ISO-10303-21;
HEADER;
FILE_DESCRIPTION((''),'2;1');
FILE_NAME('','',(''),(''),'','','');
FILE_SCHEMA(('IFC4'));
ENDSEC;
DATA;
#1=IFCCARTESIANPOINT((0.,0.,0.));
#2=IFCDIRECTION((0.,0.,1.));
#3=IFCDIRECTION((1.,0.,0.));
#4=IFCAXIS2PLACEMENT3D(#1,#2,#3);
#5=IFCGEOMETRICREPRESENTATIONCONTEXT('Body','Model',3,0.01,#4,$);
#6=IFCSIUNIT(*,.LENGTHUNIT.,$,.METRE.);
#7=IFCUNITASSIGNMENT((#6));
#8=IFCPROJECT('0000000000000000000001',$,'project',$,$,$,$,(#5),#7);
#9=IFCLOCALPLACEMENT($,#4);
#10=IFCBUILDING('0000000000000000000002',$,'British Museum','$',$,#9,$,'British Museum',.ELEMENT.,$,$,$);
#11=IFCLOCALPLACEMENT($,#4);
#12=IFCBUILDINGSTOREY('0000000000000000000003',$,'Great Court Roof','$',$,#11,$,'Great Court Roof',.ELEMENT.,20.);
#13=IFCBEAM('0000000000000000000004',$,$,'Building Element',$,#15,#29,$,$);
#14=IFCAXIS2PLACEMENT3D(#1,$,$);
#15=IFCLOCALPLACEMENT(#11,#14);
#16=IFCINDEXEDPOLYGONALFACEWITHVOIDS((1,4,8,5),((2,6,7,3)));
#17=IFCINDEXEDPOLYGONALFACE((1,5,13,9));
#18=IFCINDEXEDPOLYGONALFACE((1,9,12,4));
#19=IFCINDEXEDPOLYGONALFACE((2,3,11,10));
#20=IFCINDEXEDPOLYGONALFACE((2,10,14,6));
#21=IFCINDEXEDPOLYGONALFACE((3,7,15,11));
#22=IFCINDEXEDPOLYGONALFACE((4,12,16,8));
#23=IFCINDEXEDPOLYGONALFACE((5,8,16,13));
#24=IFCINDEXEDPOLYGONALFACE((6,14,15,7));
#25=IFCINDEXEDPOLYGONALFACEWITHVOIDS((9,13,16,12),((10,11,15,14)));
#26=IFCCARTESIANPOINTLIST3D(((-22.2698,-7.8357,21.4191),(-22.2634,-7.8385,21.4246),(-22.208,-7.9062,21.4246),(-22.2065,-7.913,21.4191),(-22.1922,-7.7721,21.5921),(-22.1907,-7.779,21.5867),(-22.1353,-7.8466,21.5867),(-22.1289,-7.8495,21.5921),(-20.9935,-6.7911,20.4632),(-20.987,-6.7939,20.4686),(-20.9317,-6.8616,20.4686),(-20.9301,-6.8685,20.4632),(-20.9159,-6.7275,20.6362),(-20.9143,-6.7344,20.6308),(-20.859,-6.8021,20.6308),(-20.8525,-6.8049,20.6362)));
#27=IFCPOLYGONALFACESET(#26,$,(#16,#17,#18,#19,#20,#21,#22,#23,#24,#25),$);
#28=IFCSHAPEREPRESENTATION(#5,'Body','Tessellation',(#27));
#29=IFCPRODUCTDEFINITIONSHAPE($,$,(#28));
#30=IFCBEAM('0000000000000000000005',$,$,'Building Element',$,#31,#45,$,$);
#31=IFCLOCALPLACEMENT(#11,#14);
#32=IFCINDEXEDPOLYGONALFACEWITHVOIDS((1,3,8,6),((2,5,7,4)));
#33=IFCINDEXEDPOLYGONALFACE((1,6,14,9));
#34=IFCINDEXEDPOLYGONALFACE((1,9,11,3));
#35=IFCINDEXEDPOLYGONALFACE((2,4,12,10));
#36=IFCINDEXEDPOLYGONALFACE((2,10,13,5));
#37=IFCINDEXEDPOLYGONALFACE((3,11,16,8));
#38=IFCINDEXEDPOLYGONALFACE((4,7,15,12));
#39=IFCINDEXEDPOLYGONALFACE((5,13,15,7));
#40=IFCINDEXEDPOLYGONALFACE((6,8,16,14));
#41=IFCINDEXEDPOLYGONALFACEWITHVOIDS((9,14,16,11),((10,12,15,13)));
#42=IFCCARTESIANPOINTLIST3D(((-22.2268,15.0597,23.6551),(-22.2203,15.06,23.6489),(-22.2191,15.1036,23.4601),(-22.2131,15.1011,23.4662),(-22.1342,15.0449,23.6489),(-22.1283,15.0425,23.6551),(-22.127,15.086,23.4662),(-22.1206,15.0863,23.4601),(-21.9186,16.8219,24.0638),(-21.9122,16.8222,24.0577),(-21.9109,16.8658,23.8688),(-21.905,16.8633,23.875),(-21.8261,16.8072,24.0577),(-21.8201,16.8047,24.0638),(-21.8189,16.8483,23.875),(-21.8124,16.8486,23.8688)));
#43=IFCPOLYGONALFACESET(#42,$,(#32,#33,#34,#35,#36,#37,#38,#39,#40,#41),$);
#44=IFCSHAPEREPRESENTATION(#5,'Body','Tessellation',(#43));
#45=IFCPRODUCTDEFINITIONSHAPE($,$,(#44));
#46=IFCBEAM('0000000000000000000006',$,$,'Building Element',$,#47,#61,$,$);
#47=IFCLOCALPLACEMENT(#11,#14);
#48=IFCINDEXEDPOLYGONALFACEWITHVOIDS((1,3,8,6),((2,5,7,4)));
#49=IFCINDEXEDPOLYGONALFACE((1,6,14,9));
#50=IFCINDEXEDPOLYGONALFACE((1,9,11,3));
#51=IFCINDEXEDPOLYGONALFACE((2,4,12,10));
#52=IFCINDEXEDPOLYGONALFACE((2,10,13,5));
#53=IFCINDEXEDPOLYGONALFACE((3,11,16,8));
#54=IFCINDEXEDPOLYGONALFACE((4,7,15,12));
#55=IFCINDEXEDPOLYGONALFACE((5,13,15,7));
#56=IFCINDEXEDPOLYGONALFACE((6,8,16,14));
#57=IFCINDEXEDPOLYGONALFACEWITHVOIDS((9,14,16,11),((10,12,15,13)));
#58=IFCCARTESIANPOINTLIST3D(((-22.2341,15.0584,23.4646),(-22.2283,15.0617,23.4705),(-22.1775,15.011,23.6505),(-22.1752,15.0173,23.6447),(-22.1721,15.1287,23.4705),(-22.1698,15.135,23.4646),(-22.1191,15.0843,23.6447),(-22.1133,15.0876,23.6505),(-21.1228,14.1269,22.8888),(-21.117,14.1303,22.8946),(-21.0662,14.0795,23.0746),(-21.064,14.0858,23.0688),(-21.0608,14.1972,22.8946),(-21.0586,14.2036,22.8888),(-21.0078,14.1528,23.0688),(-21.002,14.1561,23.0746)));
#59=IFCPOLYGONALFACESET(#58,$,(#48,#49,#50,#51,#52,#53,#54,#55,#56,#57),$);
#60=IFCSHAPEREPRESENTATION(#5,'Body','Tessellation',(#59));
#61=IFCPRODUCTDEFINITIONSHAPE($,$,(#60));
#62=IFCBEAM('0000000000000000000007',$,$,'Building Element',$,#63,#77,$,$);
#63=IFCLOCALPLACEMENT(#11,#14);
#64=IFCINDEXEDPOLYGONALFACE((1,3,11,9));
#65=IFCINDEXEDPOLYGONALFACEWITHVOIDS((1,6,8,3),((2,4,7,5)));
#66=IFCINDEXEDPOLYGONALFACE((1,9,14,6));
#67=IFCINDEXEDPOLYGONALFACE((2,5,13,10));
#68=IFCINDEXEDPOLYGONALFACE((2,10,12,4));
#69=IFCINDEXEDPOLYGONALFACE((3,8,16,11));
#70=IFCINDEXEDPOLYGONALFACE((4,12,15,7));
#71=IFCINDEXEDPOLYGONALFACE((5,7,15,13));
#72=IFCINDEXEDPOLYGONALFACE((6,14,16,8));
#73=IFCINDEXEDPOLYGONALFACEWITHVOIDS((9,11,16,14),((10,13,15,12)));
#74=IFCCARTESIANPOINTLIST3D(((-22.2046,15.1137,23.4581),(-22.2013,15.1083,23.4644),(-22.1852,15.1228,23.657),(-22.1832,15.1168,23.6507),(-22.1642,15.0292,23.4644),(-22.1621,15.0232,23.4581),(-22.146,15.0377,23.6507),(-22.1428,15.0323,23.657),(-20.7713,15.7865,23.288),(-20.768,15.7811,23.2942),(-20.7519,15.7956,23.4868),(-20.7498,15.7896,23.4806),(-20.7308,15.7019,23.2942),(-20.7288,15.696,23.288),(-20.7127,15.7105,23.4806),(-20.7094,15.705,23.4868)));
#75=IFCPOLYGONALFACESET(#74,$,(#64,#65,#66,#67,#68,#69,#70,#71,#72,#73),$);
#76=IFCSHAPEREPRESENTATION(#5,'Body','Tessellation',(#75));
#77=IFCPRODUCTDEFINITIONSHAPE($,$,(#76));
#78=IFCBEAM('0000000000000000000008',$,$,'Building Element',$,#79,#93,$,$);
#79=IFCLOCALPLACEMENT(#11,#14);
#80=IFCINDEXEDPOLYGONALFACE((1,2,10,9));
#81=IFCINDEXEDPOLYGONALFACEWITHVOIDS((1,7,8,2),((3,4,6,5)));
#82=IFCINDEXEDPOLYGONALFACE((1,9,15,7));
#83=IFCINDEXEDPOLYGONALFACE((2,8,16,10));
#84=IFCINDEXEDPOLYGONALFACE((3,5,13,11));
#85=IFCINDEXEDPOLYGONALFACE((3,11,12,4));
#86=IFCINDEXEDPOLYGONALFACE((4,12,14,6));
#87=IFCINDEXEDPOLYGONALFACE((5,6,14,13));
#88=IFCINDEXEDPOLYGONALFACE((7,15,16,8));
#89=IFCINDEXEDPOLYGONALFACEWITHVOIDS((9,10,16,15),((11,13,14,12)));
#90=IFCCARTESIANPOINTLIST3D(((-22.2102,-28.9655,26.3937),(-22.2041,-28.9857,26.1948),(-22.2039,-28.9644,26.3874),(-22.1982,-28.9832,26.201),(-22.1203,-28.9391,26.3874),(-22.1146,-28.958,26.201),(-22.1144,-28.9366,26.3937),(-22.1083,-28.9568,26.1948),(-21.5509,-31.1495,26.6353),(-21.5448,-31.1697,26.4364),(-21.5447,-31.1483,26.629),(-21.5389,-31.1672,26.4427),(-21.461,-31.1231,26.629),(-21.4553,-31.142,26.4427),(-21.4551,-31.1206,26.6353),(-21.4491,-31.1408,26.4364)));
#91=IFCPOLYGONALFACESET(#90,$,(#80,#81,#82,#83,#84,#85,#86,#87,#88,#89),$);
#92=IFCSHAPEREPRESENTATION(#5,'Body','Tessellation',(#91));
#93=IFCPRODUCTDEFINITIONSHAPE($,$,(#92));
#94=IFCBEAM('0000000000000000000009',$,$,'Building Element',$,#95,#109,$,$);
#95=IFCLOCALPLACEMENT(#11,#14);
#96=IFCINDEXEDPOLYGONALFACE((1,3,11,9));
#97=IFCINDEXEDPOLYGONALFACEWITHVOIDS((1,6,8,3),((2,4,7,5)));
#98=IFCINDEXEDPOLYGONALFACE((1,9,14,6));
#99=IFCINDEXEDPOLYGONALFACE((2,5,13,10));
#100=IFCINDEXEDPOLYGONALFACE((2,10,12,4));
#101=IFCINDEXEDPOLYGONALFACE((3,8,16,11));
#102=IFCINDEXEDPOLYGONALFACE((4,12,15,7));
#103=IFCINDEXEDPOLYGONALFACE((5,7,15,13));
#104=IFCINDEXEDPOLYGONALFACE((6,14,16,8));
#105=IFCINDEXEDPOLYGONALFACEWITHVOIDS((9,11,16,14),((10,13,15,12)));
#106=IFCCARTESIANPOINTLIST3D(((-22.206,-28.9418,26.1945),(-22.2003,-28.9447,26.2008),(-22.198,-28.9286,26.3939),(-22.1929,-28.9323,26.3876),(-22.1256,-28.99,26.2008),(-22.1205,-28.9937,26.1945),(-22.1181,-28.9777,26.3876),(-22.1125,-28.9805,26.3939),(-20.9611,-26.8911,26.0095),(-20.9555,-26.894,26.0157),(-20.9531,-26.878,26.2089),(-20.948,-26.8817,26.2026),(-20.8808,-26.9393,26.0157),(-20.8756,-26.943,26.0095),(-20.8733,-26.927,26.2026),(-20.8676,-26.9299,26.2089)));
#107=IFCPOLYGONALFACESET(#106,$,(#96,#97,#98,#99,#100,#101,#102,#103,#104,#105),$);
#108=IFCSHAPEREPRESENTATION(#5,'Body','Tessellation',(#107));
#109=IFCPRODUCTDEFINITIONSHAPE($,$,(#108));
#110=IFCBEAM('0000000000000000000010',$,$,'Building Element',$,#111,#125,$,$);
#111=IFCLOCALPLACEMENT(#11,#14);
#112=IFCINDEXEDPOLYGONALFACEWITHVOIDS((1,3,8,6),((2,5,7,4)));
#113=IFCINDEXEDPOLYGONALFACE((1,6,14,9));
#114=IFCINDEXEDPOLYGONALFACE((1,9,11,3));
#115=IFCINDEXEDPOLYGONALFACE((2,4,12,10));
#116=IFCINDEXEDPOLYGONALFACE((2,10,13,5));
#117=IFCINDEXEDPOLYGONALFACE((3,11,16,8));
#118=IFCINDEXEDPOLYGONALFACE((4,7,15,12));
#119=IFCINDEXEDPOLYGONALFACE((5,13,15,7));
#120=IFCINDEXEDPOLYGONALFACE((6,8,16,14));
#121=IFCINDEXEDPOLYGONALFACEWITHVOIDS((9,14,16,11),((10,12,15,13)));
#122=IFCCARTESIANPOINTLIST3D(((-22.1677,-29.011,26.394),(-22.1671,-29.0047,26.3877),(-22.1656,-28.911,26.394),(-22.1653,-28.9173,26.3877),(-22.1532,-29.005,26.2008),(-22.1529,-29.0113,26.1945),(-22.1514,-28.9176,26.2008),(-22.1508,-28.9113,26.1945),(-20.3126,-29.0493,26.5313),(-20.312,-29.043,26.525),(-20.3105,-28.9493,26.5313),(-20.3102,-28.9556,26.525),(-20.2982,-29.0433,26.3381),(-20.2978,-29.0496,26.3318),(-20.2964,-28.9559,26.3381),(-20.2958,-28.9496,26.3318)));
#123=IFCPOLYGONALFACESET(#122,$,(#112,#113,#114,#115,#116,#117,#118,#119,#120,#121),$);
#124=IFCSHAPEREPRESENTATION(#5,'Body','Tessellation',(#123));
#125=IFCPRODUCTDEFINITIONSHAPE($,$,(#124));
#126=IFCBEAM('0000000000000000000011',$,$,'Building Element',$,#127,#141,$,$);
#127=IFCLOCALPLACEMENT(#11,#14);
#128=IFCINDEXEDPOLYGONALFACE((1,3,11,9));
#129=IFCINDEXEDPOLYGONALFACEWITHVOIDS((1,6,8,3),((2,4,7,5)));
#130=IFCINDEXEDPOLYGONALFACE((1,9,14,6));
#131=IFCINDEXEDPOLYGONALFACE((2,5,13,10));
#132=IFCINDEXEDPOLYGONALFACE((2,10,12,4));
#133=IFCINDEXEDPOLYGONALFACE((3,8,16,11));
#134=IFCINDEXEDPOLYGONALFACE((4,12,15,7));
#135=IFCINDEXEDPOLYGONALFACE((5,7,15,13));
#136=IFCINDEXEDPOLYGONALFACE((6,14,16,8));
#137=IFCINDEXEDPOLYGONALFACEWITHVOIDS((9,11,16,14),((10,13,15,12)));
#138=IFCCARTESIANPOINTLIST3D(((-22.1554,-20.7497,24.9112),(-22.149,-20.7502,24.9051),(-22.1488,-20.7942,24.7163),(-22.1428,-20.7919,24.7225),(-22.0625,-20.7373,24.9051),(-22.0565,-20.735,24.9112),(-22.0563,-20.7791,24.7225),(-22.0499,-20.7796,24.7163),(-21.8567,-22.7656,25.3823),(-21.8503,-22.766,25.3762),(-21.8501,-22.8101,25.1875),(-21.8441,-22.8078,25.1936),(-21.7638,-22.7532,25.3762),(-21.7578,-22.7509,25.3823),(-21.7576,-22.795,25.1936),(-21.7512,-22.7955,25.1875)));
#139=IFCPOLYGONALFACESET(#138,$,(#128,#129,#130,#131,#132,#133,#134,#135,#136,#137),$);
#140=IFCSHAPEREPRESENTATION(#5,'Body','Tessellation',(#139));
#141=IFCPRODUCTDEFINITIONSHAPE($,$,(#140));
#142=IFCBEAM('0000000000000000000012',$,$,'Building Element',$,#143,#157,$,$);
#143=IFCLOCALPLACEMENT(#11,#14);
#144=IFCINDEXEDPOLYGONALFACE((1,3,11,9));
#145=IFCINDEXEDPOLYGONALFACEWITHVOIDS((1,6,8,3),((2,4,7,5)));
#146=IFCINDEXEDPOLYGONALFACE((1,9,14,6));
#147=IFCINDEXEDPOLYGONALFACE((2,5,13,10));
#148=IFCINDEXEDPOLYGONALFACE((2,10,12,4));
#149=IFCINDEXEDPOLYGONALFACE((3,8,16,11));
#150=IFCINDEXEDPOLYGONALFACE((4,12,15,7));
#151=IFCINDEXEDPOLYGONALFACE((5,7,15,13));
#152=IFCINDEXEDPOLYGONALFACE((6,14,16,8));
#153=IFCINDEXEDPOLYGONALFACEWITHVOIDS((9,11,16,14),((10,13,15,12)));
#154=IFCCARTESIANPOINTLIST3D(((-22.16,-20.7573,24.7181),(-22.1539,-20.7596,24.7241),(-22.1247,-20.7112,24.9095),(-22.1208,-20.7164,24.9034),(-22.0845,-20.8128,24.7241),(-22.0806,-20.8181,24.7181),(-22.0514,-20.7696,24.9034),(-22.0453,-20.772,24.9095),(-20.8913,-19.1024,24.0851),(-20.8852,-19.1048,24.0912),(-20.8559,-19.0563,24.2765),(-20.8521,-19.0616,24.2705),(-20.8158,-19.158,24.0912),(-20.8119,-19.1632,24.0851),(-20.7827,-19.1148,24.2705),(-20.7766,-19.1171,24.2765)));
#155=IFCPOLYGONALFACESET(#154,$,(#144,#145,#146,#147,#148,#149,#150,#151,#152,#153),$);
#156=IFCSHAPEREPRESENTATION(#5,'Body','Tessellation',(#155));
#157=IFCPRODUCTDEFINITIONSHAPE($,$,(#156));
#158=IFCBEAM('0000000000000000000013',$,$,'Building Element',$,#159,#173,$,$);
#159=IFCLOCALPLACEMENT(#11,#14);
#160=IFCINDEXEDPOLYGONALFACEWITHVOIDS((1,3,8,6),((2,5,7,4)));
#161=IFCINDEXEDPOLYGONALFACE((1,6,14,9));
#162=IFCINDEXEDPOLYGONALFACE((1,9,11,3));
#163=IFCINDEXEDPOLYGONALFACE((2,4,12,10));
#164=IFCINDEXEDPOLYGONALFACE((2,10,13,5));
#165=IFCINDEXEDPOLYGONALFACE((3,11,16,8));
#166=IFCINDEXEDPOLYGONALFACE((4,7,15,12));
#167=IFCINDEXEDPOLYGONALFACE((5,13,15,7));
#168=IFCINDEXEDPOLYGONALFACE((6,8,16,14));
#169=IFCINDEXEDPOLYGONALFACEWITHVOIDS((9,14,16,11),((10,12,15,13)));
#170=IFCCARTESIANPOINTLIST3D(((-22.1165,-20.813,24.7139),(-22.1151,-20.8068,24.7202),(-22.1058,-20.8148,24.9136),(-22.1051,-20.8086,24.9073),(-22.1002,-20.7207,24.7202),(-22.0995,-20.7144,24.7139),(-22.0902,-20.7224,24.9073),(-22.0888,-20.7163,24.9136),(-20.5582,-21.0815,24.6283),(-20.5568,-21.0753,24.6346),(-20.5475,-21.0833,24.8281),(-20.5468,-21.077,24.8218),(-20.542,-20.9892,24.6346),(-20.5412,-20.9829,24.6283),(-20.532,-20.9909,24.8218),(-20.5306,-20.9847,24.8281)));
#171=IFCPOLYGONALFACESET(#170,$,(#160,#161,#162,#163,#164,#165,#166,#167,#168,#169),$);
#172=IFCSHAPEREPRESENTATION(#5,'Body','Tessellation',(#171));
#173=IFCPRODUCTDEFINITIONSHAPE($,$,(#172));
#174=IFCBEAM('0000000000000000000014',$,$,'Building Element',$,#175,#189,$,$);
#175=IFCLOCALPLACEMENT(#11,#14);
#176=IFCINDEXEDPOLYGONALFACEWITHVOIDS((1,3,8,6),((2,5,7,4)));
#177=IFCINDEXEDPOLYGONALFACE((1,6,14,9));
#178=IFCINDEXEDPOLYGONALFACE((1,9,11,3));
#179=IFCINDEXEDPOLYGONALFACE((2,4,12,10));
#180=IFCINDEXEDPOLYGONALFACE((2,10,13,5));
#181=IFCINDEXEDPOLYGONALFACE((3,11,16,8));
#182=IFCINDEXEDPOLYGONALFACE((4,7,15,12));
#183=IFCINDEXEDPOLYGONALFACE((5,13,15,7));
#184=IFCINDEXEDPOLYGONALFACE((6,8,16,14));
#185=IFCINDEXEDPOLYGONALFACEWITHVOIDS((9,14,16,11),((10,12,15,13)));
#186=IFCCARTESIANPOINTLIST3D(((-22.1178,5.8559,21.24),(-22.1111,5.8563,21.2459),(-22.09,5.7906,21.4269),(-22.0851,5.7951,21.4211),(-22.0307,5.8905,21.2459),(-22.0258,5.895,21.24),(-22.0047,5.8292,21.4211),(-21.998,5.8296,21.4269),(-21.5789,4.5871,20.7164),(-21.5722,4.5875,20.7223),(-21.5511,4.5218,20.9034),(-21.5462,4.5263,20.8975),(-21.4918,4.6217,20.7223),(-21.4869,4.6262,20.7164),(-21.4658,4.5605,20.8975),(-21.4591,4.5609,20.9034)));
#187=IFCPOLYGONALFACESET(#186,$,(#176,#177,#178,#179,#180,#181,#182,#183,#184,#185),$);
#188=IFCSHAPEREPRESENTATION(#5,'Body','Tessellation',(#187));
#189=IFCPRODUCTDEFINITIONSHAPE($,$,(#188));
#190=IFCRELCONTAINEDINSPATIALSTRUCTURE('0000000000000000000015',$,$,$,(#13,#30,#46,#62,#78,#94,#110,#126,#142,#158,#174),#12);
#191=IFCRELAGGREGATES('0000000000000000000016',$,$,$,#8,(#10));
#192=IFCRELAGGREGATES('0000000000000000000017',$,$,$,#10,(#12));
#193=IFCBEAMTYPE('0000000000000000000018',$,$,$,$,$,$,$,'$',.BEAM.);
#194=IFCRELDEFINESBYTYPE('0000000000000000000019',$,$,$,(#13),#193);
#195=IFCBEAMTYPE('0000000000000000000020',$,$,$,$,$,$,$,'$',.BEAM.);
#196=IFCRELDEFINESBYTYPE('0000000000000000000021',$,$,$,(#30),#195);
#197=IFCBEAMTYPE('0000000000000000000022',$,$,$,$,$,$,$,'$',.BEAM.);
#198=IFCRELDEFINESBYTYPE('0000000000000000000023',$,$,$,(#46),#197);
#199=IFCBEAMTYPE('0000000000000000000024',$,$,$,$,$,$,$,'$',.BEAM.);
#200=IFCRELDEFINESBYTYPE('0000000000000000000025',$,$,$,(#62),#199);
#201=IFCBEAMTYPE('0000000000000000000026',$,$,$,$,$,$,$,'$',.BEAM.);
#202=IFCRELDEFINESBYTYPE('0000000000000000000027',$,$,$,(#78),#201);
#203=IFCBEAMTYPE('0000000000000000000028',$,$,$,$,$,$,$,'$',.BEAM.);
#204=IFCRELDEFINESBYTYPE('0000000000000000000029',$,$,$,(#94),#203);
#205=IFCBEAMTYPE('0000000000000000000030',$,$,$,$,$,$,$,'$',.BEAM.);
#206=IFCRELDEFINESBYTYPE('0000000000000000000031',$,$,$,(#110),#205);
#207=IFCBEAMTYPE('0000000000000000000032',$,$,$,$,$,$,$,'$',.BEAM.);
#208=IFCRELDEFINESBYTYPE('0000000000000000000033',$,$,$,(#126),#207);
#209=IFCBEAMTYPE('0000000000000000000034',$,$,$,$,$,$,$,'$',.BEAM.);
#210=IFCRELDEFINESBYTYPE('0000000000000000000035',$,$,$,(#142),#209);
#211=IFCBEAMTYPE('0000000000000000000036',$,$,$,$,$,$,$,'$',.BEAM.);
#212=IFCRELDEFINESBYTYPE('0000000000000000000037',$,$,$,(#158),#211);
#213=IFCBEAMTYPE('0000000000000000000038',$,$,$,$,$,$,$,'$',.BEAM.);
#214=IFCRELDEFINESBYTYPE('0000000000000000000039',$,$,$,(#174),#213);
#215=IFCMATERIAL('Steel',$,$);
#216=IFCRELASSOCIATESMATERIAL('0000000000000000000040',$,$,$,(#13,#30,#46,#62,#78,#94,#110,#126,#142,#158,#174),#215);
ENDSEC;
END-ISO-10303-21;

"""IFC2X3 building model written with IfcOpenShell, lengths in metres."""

from ifc_helpers import new_model, si_unit, frame, origin_with_axes, origin_2d, place, context, project, spatial, hollow_rectangle, extrude, material, type_object, element, save


model = new_model("IFC2X3")

# Units and contexts
model_context = context("Model", 3, precision=0.01, world=origin_with_axes(), identifier="Body")
ifc_project = project(units=[si_unit("LENGTHUNIT", "METRE")], contexts=[model_context])

# Building, storey
building_placement = place(None, origin_with_axes())
building = spatial("IfcBuilding", under=ifc_project, at=building_placement, Name="British Museum", Description="$", LongName="British Museum", CompositionType="ELEMENT")
storey_placement = place(None, origin_with_axes())
storey = spatial("IfcBuildingStorey", under=building, at=storey_placement, Name="Great Court Roof", Description="$", LongName="Great Court Roof", CompositionType="ELEMENT", Elevation=20.0)

# Beams
ifc_material = material(Name="Steel")
beam_type_1 = type_object("IfcBeamType", ElementType="$", PredefinedType="BEAM")
beam_1_placement = place(None, origin_with_axes())
element("IfcBeam", 1, at=beam_1_placement, inside=storey, type_object=beam_type_1, material=ifc_material, Description="Building Element", context=model_context, shape_type="SweptSolid", body=[
    extrude(hollow_rectangle(XDim=0.1, YDim=0.2, WallThickness=0.0063, InnerFilletRadius=0.0, OuterFilletRadius=0.0, at=origin_2d()), frame((-22.1993, -7.8426, 21.5056), z_axis=(0.669537, 0.547962, -0.501455), x_axis=(-0.633348, 0.773867, 0.0)), (0.0, 0.0, 1.0), 1.9063),
])
beam_type_2 = type_object("IfcBeamType", ElementType="$", PredefinedType="BEAM")
beam_2_placement = place(None, origin_with_axes())
element("IfcBeam", 2, at=beam_2_placement, inside=storey, type_object=beam_type_2, material=ifc_material, Description="Building Element", context=model_context, shape_type="SweptSolid", body=[
    extrude(hollow_rectangle(XDim=0.1, YDim=0.2, WallThickness=0.0063, InnerFilletRadius=0.0, OuterFilletRadius=0.0, at=origin_2d()), frame((-22.1737, 15.073, 23.5576), z_axis=(0.167927, 0.960307, 0.222736), x_axis=(-0.985052, 0.172255, 0.0)), (0.0, 0.0, 1.0), 1.8351),
])
beam_type_3 = type_object("IfcBeamType", ElementType="$", PredefinedType="BEAM")
beam_3_placement = place(None, origin_with_axes())
element("IfcBeam", 3, at=beam_3_placement, inside=storey, type_object=beam_type_3, material=ifc_material, Description="Building Element", context=model_context, shape_type="SweptSolid", body=[
    extrude(hollow_rectangle(XDim=0.1, YDim=0.2, WallThickness=0.0063, InnerFilletRadius=0.0, OuterFilletRadius=0.0, at=origin_2d()), frame((-22.1737, 15.073, 23.5576), z_axis=(0.712262, -0.597026, -0.36911), x_axis=(0.642388, 0.76638, 0.0)), (0.0, 0.0, 1.0), 1.5602),
])
beam_type_4 = type_object("IfcBeamType", ElementType="$", PredefinedType="BEAM")
beam_4_placement = place(None, origin_with_axes())
element("IfcBeam", 4, at=beam_4_placement, inside=storey, type_object=beam_type_4, material=ifc_material, Description="Building Element", context=model_context, shape_type="SweptSolid", body=[
    extrude(hollow_rectangle(XDim=0.1, YDim=0.2, WallThickness=0.0063, InnerFilletRadius=0.0, OuterFilletRadius=0.0, at=origin_2d()), frame((-22.1737, 15.073, 23.5576), z_axis=(0.900062, 0.422456, -0.106863), x_axis=(-0.424889, 0.905246, 0.0)), (0.0, 0.0, 1.0), 1.5925),
])
beam_type_5 = type_object("IfcBeamType", ElementType="$", PredefinedType="BEAM")
beam_5_placement = place(None, origin_with_axes())
element("IfcBeam", 5, at=beam_5_placement, inside=storey, type_object=beam_type_5, material=ifc_material, Description="Building Element", context=model_context, shape_type="SweptSolid", body=[
    extrude(hollow_rectangle(XDim=0.1, YDim=0.2, WallThickness=0.0063, InnerFilletRadius=0.0, OuterFilletRadius=0.0, at=origin_2d()), frame((-22.1592, -28.9612, 26.2942), z_axis=(0.287381, -0.952007, 0.105328), x_axis=(0.957333, 0.288988, 0.0)), (0.0, 0.0, 1.0), 2.2941),
])
beam_type_6 = type_object("IfcBeamType", ElementType="$", PredefinedType="BEAM")
beam_6_placement = place(None, origin_with_axes())
element("IfcBeam", 6, at=beam_6_placement, inside=storey, type_object=beam_type_6, material=ifc_material, Description="Building Element", context=model_context, shape_type="SweptSolid", body=[
    extrude(hollow_rectangle(XDim=0.1, YDim=0.2, WallThickness=0.0063, InnerFilletRadius=0.0, OuterFilletRadius=0.0, at=origin_2d()), frame((-22.1592, -28.9612, 26.2942), z_axis=(0.517385, 0.852289, -0.076917), x_axis=(-0.854821, 0.518922, 0.0)), (0.0, 0.0, 1.0), 2.4061),
])
beam_type_7 = type_object("IfcBeamType", ElementType="$", PredefinedType="BEAM")
beam_7_placement = place(None, origin_with_axes())
element("IfcBeam", 7, at=beam_7_placement, inside=storey, type_object=beam_type_7, material=ifc_material, Description="Building Element", context=model_context, shape_type="SweptSolid", body=[
    extrude(hollow_rectangle(XDim=0.1, YDim=0.2, WallThickness=0.0063, InnerFilletRadius=0.0, OuterFilletRadius=0.0, at=origin_2d()), frame((-22.1592, -28.9612, 26.2942), z_axis=(0.997061, -0.020562, 0.073799), x_axis=(0.020618, 0.999787, 0.0)), (0.0, 0.0, 1.0), 1.8605),
])
beam_type_8 = type_object("IfcBeamType", ElementType="$", PredefinedType="BEAM")
beam_8_placement = place(None, origin_with_axes())
element("IfcBeam", 8, at=beam_8_placement, inside=storey, type_object=beam_type_8, material=ifc_material, Description="Building Element", context=model_context, shape_type="SweptSolid", body=[
    extrude(hollow_rectangle(XDim=0.1, YDim=0.2, WallThickness=0.0063, InnerFilletRadius=0.0, OuterFilletRadius=0.0, at=origin_2d()), frame((-22.1026, -20.7646, 24.8138), z_axis=(0.142802, -0.96378, 0.225246), x_axis=(0.989201, 0.146568, 0.0)), (0.0, 0.0, 1.0), 2.0916),
])
beam_type_9 = type_object("IfcBeamType", ElementType="$", PredefinedType="BEAM")
beam_9_placement = place(None, origin_with_axes())
element("IfcBeam", 9, at=beam_9_placement, inside=storey, type_object=beam_type_9, material=ifc_material, Description="Building Element", context=model_context, shape_type="SweptSolid", body=[
    extrude(hollow_rectangle(XDim=0.1, YDim=0.2, WallThickness=0.0063, InnerFilletRadius=0.0, OuterFilletRadius=0.0, at=origin_2d()), frame((-22.1026, -20.7646, 24.8138), z_axis=(0.582199, 0.759396, -0.290451), x_axis=(-0.793609, 0.608428, 0.0)), (0.0, 0.0, 1.0), 2.1792),
])
beam_type_10 = type_object("IfcBeamType", ElementType="$", PredefinedType="BEAM")
beam_10_placement = place(None, origin_with_axes())
element("IfcBeam", 10, at=beam_10_placement, inside=storey, type_object=beam_type_10, material=ifc_material, Description="Building Element", context=model_context, shape_type="SweptSolid", body=[
    extrude(hollow_rectangle(XDim=0.1, YDim=0.2, WallThickness=0.0063, InnerFilletRadius=0.0, OuterFilletRadius=0.0, at=origin_2d()), frame((-22.1026, -20.7646, 24.8138), z_axis=(0.984041, -0.169538, -0.054038), x_axis=(0.169786, 0.985481, 0.0)), (0.0, 0.0, 1.0), 1.5835),
])
beam_type_11 = type_object("IfcBeamType", ElementType="$", PredefinedType="BEAM")
beam_11_placement = place(None, origin_with_axes())
element("IfcBeam", 11, at=beam_11_placement, inside=storey, type_object=beam_type_11, material=ifc_material, Description="Building Element", context=model_context, shape_type="SweptSolid", body=[
    extrude(hollow_rectangle(XDim=0.1, YDim=0.2, WallThickness=0.0063, InnerFilletRadius=0.0, OuterFilletRadius=0.0, at=origin_2d()), frame((-22.0579, 5.8428, 21.3335), z_axis=(0.365468, -0.86044, -0.355071), x_axis=(0.920415, 0.390942, 0.0)), (0.0, 0.0, 1.0), 1.4746),
])

save(model, "model.ifc")
